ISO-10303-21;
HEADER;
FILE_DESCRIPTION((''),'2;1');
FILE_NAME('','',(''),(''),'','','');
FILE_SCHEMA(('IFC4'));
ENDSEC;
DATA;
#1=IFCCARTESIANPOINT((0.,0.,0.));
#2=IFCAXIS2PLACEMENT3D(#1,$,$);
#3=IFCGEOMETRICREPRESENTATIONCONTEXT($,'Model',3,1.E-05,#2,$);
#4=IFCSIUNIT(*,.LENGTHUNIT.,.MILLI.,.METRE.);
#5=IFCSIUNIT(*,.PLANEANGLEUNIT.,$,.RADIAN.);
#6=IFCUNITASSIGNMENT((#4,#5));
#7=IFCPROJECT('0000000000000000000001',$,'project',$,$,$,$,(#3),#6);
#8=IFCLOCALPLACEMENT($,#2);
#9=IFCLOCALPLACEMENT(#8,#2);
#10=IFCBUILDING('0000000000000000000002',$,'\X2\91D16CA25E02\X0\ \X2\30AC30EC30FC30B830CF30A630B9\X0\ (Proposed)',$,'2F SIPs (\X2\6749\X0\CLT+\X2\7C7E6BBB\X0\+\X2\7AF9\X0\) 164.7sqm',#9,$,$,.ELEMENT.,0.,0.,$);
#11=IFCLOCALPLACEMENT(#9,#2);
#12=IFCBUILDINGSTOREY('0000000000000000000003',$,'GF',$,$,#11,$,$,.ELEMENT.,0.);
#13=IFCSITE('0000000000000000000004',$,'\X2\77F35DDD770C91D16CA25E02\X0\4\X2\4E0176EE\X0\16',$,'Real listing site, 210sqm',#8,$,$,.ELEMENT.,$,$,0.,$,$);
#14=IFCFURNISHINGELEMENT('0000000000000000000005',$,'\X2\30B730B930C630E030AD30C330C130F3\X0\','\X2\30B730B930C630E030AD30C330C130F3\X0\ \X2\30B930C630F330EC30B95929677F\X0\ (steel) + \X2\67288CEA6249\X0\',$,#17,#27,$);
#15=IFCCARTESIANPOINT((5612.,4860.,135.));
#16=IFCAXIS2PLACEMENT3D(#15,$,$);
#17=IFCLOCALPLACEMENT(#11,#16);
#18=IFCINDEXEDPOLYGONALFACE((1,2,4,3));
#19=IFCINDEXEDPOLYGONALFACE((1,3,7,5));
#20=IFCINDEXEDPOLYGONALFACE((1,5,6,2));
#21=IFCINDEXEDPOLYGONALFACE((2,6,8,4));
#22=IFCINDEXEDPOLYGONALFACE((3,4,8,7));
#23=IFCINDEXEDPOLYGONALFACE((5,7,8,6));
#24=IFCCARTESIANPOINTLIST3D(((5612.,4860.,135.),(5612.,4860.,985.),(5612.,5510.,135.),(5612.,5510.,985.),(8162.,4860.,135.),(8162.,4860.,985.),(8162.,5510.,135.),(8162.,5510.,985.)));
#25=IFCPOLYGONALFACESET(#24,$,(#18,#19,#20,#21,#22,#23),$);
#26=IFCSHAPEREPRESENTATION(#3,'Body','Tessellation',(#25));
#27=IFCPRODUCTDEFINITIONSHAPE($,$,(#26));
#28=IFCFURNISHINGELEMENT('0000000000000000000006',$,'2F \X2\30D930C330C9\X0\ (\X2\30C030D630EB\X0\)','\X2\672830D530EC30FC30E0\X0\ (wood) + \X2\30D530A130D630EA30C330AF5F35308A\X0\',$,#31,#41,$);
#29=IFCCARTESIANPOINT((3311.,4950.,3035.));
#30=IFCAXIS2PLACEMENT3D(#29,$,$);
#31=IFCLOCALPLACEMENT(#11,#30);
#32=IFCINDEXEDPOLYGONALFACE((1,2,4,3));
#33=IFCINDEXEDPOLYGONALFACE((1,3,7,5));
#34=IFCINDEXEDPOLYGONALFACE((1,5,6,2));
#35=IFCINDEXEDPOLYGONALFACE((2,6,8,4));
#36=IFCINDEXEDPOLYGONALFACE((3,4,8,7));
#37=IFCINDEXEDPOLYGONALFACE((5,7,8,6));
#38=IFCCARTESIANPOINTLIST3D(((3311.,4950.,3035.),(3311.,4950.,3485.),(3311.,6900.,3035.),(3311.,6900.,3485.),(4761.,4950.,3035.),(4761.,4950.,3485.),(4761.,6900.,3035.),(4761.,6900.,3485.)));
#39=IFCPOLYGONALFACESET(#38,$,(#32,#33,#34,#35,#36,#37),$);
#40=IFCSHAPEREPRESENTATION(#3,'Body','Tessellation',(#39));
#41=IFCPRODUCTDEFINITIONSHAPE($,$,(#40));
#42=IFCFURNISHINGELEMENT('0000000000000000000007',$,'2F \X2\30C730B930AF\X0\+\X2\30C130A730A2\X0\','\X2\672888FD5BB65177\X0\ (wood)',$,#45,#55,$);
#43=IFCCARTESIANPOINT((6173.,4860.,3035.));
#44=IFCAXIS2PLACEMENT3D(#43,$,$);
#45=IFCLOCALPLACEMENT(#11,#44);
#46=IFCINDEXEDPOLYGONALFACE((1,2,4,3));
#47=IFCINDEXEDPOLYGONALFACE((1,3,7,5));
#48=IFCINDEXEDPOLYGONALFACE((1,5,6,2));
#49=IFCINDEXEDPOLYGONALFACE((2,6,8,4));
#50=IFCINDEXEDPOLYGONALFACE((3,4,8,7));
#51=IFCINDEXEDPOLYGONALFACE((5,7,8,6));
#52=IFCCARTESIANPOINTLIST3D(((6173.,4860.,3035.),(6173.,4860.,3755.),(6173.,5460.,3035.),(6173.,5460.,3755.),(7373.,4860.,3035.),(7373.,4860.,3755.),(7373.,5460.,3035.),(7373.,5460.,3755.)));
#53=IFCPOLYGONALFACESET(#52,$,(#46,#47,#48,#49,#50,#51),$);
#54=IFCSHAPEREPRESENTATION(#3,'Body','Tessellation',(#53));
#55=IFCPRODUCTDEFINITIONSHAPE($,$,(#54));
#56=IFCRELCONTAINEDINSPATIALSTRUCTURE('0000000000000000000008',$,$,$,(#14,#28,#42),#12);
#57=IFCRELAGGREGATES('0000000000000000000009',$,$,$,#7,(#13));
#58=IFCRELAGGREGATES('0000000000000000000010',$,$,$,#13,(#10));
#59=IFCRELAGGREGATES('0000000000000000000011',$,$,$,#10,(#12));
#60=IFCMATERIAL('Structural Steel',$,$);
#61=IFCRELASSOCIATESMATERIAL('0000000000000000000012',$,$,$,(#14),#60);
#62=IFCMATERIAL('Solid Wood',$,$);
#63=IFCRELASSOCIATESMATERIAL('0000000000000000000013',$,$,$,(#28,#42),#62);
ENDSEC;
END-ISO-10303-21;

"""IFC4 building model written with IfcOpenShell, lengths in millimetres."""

from ifc_helpers import new_model, si_unit, frame, frame_2d, origin, place, context, project, spatial, rectangle, extrude, material, element, save


model = new_model("IFC4")

# Units and contexts
model_context = context("Model", 3, precision=1e-05, world=origin())
ifc_project = project(units=[si_unit("LENGTHUNIT", "METRE", prefix="MILLI"), si_unit("PLANEANGLEUNIT", "RADIAN")], contexts=[model_context])

# Site, building, storey
site_placement = place(None, origin())
site = spatial("IfcSite", under=ifc_project, at=site_placement, Name="石川県金沢市4丁目16", ObjectType="Real listing site, 210sqm", CompositionType="ELEMENT", RefElevation=0.0)
building_placement = place(site_placement, origin())
building = spatial("IfcBuilding", under=site, at=building_placement, Name="金沢市 ガレージハウス (Proposed)", ObjectType="2F SIPs (杉CLT+籾殻+竹) 164.7sqm", CompositionType="ELEMENT", ElevationOfRefHeight=0.0, ElevationOfTerrain=0.0)
storey_placement = place(building_placement, origin())
storey = spatial("IfcBuildingStorey", under=building, at=storey_placement, Name="GF", CompositionType="ELEMENT", Elevation=0.0)

# Shared definitions
ifc_material_1 = material(Name="Solid Wood")

# Shared definitions
ifc_material_2 = material(Name="Structural Steel")

# Furnishing elements
furnishing_1_placement = place(storey_placement, frame((5612.0, 4860.0, 135.0)))
element("IfcFurnishingElement", 1, at=furnishing_1_placement, inside=storey, material=ifc_material_2, Name="システムキッチン", Description="システムキッチン ステンレス天板 (steel) + 木質扉", context=model_context, shape_type="SweptSolid", body=[
    extrude(rectangle(XDim=2550.0, YDim=650.0, at=frame_2d((1275.0, 325.0))), frame((5612.0, 4860.0, 135.0)), (0.0, 0.0, 1.0), 850.0),
])
furnishing_2_placement = place(storey_placement, frame((3311.0, 4950.0, 3035.0)))
element("IfcFurnishingElement", 2, at=furnishing_2_placement, inside=storey, material=ifc_material_1, Name="2F ベッド (ダブル)", Description="木フレーム (wood) + ファブリック張り", context=model_context, shape_type="SweptSolid", body=[
    extrude(rectangle(XDim=1450.0, YDim=1950.0, at=frame_2d((725.0, 975.0))), frame((3311.0, 4950.0, 3035.0)), (0.0, 0.0, 1.0), 450.0),
])
furnishing_3_placement = place(storey_placement, frame((6173.0, 4860.0, 3035.0)))
element("IfcFurnishingElement", 3, at=furnishing_3_placement, inside=storey, material=ifc_material_1, Name="2F デスク+チェア", Description="木製家具 (wood)", context=model_context, shape_type="SweptSolid", body=[
    extrude(rectangle(XDim=1200.0, YDim=600.0, at=frame_2d((600.0, 300.0))), frame((6173.0, 4860.0, 3035.0)), (0.0, 0.0, 1.0), 720.0),
])

save(model, "model.ifc")
